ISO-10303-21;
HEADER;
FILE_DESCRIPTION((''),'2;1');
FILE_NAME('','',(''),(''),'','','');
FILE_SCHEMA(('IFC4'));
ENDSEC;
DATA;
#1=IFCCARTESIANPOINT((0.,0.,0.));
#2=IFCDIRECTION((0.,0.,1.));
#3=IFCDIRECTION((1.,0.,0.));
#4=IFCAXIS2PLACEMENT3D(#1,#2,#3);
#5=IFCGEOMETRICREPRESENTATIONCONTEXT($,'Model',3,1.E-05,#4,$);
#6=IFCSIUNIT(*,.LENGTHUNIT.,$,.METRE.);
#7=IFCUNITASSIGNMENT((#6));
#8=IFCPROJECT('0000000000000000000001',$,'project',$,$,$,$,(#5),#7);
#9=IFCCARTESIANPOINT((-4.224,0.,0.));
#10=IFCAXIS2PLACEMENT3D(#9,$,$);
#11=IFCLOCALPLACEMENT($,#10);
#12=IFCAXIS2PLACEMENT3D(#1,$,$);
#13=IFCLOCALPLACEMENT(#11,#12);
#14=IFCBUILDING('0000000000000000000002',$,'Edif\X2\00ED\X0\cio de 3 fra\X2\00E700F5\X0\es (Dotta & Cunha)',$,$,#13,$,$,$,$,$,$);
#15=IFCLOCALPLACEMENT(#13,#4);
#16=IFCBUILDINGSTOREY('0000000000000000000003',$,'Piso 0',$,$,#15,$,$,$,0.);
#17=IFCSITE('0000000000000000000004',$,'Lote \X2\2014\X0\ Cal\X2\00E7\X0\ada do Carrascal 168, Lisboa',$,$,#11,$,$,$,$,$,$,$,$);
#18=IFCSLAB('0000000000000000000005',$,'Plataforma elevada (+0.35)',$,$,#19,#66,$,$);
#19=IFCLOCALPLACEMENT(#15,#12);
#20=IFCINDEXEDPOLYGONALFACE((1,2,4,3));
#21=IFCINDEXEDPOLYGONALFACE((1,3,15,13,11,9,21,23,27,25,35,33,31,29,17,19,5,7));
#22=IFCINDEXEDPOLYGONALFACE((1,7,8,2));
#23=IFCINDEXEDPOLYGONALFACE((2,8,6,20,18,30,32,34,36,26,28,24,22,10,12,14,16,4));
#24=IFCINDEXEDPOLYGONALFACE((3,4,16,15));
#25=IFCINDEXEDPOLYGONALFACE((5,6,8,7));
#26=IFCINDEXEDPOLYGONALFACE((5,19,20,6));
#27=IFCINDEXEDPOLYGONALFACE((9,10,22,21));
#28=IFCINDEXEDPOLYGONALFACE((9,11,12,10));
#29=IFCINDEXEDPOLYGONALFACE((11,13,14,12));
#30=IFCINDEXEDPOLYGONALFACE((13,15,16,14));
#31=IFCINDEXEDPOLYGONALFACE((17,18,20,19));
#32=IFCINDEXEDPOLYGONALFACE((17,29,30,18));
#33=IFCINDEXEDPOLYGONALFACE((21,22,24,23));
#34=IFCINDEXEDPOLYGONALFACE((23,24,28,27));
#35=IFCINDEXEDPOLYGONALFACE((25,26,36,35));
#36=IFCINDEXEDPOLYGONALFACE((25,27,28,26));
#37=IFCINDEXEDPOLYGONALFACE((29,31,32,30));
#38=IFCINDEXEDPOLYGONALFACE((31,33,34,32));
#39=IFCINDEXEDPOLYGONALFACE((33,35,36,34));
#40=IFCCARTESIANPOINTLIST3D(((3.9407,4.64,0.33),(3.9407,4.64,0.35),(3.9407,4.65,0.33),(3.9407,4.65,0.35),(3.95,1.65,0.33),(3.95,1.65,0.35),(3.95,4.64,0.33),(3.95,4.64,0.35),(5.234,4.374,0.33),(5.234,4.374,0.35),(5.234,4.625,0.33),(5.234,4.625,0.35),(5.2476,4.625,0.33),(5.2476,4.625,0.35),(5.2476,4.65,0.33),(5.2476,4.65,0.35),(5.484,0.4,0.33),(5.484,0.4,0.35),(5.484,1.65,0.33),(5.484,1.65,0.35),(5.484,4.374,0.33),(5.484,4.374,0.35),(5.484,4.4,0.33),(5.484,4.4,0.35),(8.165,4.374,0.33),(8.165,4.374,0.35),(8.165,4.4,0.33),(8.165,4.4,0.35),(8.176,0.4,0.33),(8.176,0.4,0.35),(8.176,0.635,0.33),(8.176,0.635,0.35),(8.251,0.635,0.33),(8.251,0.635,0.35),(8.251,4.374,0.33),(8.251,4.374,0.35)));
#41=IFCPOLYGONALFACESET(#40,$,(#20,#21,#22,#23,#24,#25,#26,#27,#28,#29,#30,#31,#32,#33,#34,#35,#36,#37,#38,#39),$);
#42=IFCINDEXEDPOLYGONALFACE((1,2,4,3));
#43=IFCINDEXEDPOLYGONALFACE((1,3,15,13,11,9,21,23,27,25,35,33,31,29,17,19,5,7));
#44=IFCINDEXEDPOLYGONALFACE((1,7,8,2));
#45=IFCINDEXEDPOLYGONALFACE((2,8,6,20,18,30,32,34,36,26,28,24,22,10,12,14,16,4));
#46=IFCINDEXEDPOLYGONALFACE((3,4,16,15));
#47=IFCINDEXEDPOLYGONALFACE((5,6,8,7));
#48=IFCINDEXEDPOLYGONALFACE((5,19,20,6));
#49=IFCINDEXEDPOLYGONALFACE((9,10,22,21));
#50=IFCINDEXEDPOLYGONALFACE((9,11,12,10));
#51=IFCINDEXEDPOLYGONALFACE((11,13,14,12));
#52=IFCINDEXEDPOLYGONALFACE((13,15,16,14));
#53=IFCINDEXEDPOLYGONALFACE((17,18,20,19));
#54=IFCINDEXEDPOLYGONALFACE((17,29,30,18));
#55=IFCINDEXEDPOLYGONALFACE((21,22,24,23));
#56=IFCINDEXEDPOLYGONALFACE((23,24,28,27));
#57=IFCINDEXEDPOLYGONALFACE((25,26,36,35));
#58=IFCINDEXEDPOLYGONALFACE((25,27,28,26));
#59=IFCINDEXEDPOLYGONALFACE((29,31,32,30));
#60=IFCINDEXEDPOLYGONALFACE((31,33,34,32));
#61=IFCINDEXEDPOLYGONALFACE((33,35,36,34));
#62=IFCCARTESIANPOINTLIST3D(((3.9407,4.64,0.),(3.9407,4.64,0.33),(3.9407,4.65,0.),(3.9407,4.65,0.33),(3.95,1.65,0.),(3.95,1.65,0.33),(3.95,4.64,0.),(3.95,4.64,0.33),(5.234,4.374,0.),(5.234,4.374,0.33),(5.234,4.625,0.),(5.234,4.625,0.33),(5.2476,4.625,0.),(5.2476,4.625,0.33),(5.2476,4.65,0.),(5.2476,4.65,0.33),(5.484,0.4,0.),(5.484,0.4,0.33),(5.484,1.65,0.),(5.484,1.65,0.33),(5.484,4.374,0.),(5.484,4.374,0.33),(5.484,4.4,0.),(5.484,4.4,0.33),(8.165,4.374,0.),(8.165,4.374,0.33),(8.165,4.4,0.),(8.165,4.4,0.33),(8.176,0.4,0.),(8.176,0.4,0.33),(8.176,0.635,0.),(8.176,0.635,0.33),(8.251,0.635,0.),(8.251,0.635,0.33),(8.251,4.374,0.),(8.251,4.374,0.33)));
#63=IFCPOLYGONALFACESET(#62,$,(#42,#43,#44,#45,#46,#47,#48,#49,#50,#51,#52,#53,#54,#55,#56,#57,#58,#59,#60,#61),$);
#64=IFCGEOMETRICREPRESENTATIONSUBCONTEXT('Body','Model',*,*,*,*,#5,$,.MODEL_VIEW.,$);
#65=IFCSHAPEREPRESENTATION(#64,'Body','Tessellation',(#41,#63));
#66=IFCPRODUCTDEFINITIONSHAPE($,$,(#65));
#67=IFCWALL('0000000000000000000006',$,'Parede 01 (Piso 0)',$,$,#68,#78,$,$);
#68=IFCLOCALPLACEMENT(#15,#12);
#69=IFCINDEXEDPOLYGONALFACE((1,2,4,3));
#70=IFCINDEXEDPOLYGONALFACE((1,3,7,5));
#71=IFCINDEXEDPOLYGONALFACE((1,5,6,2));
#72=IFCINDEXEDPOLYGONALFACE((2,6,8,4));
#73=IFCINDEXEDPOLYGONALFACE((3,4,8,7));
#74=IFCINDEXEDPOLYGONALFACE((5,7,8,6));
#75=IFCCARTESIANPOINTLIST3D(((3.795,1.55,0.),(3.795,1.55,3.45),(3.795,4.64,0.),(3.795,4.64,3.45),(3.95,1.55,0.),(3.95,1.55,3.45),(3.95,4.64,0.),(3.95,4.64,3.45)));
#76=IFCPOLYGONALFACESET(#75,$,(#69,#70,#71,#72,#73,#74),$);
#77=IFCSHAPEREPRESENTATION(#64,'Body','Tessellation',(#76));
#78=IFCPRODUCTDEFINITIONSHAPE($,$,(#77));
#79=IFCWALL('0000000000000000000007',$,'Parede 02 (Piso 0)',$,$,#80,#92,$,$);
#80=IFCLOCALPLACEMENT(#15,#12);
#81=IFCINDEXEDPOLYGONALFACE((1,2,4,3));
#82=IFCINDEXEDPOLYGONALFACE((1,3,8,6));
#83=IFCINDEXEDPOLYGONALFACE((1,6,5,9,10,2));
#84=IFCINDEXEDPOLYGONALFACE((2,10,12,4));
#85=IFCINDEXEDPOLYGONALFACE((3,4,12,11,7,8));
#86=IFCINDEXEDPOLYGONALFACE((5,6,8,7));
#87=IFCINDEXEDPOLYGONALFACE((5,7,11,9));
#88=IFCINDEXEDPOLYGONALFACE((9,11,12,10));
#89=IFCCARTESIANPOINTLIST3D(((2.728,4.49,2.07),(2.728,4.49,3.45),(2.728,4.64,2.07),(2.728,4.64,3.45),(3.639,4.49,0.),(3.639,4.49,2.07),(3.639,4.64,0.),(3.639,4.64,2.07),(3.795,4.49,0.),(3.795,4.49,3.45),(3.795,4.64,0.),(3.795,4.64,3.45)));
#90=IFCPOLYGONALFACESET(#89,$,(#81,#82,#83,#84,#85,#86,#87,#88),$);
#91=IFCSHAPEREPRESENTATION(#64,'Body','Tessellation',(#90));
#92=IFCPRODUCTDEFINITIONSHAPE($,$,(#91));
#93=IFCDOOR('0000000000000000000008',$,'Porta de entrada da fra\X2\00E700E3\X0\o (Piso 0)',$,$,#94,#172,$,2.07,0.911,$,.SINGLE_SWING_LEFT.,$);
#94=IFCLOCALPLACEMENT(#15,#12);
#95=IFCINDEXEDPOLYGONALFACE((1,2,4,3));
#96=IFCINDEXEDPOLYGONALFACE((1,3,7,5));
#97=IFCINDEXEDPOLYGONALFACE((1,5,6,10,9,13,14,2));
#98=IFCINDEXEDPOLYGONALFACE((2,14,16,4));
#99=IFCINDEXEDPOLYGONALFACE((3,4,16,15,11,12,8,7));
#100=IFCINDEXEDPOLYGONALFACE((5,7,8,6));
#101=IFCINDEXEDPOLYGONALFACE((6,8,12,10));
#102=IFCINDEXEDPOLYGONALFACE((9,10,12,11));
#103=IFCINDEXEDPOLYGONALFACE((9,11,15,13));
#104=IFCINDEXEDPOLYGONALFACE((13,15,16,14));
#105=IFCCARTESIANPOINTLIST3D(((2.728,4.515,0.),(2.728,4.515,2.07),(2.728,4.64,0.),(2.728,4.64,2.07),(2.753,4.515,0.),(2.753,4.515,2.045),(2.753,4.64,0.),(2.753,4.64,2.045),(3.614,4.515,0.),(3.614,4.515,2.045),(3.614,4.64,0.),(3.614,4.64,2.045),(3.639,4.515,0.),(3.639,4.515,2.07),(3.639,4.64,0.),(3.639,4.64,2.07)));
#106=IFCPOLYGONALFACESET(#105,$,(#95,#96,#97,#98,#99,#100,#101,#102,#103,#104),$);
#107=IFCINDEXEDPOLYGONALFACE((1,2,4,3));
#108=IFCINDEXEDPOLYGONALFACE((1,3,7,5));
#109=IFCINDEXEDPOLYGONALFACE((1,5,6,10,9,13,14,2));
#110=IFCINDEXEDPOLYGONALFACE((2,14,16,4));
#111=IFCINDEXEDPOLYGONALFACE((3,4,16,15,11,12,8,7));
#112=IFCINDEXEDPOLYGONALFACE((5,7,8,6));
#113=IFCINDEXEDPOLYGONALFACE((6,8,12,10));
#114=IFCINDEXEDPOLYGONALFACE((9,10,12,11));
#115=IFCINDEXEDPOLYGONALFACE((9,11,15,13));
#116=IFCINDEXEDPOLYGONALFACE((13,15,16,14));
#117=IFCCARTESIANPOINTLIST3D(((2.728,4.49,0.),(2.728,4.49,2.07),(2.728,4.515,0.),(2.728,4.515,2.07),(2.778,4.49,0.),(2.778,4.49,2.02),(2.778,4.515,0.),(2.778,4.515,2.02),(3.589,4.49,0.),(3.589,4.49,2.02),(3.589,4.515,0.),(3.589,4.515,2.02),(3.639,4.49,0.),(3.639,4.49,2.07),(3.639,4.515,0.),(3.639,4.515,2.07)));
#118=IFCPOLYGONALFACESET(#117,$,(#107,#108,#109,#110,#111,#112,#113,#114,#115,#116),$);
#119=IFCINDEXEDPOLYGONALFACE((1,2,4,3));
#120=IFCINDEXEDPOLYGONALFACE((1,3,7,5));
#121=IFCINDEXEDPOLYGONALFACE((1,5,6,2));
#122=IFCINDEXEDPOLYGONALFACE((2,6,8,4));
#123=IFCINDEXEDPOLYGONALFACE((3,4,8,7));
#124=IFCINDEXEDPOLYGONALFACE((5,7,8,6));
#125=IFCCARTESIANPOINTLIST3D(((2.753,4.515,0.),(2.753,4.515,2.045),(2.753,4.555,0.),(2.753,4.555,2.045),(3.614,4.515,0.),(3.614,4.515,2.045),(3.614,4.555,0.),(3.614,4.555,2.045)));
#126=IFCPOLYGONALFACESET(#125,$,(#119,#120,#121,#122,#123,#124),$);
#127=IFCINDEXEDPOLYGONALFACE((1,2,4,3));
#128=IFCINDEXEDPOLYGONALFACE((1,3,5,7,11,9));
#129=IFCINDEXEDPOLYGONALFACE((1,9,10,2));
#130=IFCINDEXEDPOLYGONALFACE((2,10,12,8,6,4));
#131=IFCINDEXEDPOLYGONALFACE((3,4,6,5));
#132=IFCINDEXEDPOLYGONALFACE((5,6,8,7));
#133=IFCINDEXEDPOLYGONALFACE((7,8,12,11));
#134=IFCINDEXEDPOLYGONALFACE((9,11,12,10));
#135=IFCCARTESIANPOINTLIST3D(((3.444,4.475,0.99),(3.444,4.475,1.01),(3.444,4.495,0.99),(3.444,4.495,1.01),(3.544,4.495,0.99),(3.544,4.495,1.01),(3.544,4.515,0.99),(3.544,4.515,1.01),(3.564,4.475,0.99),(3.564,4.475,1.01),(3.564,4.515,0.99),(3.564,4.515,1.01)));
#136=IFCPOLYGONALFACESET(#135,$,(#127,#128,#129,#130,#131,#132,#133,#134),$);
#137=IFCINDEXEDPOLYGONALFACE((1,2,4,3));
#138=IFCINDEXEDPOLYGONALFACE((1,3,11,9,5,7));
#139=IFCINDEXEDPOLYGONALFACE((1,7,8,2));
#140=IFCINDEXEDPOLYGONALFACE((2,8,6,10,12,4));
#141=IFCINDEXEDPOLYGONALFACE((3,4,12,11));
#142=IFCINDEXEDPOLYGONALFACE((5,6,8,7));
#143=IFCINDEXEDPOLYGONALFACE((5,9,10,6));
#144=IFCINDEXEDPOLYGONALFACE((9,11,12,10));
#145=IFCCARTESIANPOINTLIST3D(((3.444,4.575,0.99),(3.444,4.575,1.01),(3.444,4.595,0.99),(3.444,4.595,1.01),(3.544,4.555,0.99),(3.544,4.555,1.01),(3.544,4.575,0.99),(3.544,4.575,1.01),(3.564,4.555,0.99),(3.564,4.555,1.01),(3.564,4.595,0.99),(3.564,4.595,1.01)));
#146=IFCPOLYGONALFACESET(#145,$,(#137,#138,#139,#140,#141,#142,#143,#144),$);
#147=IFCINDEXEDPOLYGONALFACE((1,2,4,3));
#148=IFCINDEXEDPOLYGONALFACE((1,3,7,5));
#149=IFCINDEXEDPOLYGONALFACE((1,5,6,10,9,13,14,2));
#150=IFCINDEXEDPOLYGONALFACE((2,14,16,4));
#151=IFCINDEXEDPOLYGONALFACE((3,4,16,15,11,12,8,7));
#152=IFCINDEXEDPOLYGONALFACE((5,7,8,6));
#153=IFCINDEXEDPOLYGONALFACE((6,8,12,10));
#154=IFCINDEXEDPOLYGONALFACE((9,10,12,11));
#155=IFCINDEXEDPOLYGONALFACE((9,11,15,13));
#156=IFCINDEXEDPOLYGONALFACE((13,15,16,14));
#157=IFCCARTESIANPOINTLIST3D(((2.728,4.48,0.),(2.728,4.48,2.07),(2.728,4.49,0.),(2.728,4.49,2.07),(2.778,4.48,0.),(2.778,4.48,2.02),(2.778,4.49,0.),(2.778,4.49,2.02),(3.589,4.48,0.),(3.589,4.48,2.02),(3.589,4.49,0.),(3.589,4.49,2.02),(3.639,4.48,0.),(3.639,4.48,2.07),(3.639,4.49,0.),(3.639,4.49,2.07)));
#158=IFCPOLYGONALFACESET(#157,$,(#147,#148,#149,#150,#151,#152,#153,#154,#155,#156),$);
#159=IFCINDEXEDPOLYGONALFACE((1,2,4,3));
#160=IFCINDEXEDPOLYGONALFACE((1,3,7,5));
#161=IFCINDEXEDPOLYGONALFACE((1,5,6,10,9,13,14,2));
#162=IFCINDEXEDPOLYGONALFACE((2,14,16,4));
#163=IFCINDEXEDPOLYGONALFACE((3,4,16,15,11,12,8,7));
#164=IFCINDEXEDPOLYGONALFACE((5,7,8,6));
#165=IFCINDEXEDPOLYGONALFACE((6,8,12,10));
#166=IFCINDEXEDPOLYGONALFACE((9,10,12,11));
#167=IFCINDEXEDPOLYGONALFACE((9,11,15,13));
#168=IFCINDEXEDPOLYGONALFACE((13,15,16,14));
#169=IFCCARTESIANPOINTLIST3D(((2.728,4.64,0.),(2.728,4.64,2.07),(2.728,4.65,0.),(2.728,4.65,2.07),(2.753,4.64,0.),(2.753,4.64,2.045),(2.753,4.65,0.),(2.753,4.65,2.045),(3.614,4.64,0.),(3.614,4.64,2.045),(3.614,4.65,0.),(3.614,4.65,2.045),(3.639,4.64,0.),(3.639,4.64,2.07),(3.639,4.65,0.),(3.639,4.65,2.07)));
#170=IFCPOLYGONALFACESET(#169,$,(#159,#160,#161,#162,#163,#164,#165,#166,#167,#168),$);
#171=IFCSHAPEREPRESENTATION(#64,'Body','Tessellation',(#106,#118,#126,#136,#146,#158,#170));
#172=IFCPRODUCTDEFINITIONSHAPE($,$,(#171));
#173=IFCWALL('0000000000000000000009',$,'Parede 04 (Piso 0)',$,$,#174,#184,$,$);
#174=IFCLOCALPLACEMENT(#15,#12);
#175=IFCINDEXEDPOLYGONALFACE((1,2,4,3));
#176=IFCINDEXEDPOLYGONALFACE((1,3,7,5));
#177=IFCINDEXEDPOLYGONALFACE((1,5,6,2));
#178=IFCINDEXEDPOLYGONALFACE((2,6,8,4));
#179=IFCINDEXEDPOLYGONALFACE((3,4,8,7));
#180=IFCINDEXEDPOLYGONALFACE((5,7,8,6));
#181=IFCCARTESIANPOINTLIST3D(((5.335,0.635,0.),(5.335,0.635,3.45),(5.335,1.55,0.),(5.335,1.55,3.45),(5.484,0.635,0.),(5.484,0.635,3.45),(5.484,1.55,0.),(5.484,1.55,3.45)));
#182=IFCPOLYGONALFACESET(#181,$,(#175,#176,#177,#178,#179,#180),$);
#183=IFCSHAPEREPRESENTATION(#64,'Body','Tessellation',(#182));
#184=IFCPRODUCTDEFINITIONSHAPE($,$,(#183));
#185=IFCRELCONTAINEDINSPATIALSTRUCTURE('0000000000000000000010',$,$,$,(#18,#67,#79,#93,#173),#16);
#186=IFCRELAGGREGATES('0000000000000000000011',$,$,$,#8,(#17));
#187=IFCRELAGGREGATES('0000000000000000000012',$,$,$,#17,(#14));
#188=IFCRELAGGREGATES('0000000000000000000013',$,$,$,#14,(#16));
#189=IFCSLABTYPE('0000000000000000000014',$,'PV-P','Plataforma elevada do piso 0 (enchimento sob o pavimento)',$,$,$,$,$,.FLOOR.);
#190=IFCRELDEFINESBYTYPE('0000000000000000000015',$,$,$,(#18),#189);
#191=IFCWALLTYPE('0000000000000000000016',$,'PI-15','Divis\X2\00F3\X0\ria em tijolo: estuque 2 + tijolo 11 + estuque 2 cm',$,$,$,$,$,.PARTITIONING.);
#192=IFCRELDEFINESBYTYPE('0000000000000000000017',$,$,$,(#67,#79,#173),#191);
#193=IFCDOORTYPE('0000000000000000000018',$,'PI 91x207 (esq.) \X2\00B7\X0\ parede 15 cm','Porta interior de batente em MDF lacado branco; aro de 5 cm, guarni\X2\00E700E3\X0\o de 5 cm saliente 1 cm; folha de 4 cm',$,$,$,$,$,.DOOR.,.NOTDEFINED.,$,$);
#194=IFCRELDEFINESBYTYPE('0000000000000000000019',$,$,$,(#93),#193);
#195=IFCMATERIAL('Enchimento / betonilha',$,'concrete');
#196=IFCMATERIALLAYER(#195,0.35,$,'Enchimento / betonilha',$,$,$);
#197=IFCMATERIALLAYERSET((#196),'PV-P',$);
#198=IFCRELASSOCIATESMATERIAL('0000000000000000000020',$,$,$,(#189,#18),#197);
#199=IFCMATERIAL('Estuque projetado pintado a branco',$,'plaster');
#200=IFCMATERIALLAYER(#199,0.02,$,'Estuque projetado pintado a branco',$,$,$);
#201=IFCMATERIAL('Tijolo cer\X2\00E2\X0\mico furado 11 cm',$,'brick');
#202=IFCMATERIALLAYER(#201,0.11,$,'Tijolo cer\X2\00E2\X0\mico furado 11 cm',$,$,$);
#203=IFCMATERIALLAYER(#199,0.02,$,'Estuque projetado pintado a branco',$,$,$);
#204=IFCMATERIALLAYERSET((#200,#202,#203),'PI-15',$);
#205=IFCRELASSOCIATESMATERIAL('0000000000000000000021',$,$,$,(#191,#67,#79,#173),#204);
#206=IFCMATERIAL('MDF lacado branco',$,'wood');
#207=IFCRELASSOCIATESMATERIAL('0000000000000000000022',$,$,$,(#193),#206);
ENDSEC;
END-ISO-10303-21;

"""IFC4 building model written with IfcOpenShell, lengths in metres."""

from ifc_helpers import new_model, si_unit, frame, origin, origin_with_axes, place, context, subcontext, project, spatial, line, indexed_curve, outline, extrude, source, transform, mapped, material, layer, layer_set, layer_usage, type_object, type_shapes, element, fill, save


model = new_model("IFC4")

# Units and contexts
model_context = context("Model", 3, precision=1e-05, world=origin_with_axes())
body_context = subcontext(model_context, "Body", "Model", "MODEL_VIEW")
ifc_project = project(units=[si_unit("LENGTHUNIT", "METRE")], contexts=[model_context])

# Site, building, storey
site_placement = place(None, frame((-4.224, 0.0, 0.0)))
site = spatial("IfcSite", under=ifc_project, at=site_placement, Name="Lote — Calçada do Carrascal 168, Lisboa")
building_placement = place(site_placement, origin())
building = spatial("IfcBuilding", under=site, at=building_placement, Name="Edifício de 3 frações (Dotta & Cunha)")
storey_placement = place(building_placement, origin_with_axes())
storey = spatial("IfcBuildingStorey", under=building, at=storey_placement, Name="Piso 0", Elevation=0.0)

# Slab
ifc_material_1 = material(Name="Enchimento / betonilha", Category="concrete")
ifc_layer_1 = layer(ifc_material_1, 0.35, Name="Enchimento / betonilha")
ifc_layer_set_1 = layer_set([ifc_layer_1], Name="PV-P")
slab_type = type_object("IfcSlabType", Name="PV-P", Description="Plataforma elevada do piso 0 (enchimento sob o pavimento)", PredefinedType="FLOOR", material=ifc_layer_set_1)
ifc_layer_usage_1 = layer_usage(ifc_layer_set_1, "AXIS3", "POSITIVE", 0.0)
slab_1_placement = place(storey_placement, origin_with_axes())
element("IfcSlab", 1, at=slab_1_placement, inside=storey, type_object=slab_type, material=ifc_layer_usage_1, Name="Plataforma elevada (+0.35)", context=body_context, shape_type="SweptSolid", body=[
    extrude(outline(indexed_curve([(5.484, 0.4), (5.484, 1.65), (3.95, 1.65), (3.95, 4.64), (3.9407, 4.64), (3.9407, 4.65), (5.2476, 4.65), (5.2476, 4.625), (5.234, 4.625), (5.234, 4.374), (5.484, 4.374), (5.484, 4.4), (8.165, 4.4), (8.165, 4.374), (8.251, 4.374), (8.251, 0.635), (8.176, 0.635), (8.176, 0.4)], segments=[line(1, 2, 3, 4, 5, 6, 7, 8, 9, 10, 11, 12, 13, 14, 15, 16, 17, 18, 1)])), frame((0.0, 0.0, 0.33), z_axis=(0.0, 0.0, 1.0), x_axis=(1.0, 0.0, 0.0)), (0.0, 0.0, 1.0), 0.02),
    extrude(outline(indexed_curve([(5.484, 0.4), (5.484, 1.65), (3.95, 1.65), (3.95, 4.64), (3.9407, 4.64), (3.9407, 4.65), (5.2476, 4.65), (5.2476, 4.625), (5.234, 4.625), (5.234, 4.374), (5.484, 4.374), (5.484, 4.4), (8.165, 4.4), (8.165, 4.374), (8.251, 4.374), (8.251, 0.635), (8.176, 0.635), (8.176, 0.4)], segments=[line(1, 2, 3, 4, 5, 6, 7, 8, 9, 10, 11, 12, 13, 14, 15, 16, 17, 18, 1)])), origin_with_axes(), (0.0, 0.0, 1.0), 0.33),
])

# Wall
ifc_material_2 = material(Name="Estuque projetado pintado a branco", Category="plaster")
ifc_layer_2 = layer(ifc_material_2, 0.02, Name="Estuque projetado pintado a branco")
ifc_material_3 = material(Name="Tijolo cerâmico furado 11 cm", Category="brick")
ifc_layer_3 = layer(ifc_material_3, 0.11, Name="Tijolo cerâmico furado 11 cm")
ifc_layer_4 = layer(ifc_material_2, 0.02, Name="Estuque projetado pintado a branco")
ifc_layer_set_2 = layer_set([ifc_layer_2, ifc_layer_3, ifc_layer_4], Name="PI-15")
ifc_layer_usage_2 = layer_usage(ifc_layer_set_2, "AXIS2", "POSITIVE", 0.0)
wall_type_1 = type_object("IfcWallType", Name="PI-15", Description="Divisória em tijolo: estuque 2 + tijolo 11 + estuque 2 cm", PredefinedType="PARTITIONING", material=ifc_layer_set_2)
wall_1_placement = place(storey_placement, origin_with_axes())
element("IfcWall", 2, at=wall_1_placement, inside=storey, type_object=wall_type_1, material=ifc_layer_usage_2, Name="Parede 01 (Piso 0)", context=body_context, shape_type="SweptSolid", body=[
    extrude(outline(indexed_curve([(3.95, 1.55), (3.95, 4.64), (3.795, 4.64), (3.795, 1.55)], segments=[line(1, 2, 3, 4, 1)])), origin_with_axes(), (0.0, 0.0, 1.0), 3.45),
])

# Wall, opening, door
ifc_layer_usage_3 = layer_usage(ifc_layer_set_2, "AXIS2", "POSITIVE", 0.0)
wall_2_placement = place(storey_placement, origin_with_axes())
wall_2 = element("IfcWall", 3, at=wall_2_placement, inside=storey, type_object=wall_type_1, material=ifc_layer_usage_3, Name="Parede 02 (Piso 0)", context=body_context, shape_type="SweptSolid", body=[
    extrude(outline(indexed_curve([(3.795, 4.49), (3.795, 4.64), (2.728, 4.64), (2.728, 4.49)], segments=[line(1, 2, 3, 4, 1)])), origin_with_axes(), (0.0, 0.0, 1.0), 3.45),
])
opening_placement = place(wall_2_placement, origin_with_axes())
opening = element("IfcOpeningElement", 4, at=opening_placement, cuts=wall_2, context=body_context, shape_type="SweptSolid", body=[
    extrude(outline(indexed_curve([(3.639, 4.488), (3.639, 4.642), (2.728, 4.642), (2.728, 4.488)], segments=[line(1, 2, 3, 4, 1)])), origin_with_axes(), (0.0, 0.0, 1.0), 2.07),
])
ifc_material_4 = material(Name="MDF lacado branco", Category="wood")
door_type = type_object("IfcDoorType", Name="PI 91x207 (esq.) · parede 15 cm", Description="Porta interior de batente em MDF lacado branco; aro de 5 cm, guarnição de 5 cm saliente 1 cm; folha de 4 cm", OperationType="NOTDEFINED", PredefinedType="DOOR", material=ifc_material_4)
shared_shape = source(origin_with_axes(), body_context, "Body", "SweptSolid", [
    extrude(outline(indexed_curve([(0.0, 0.0), (0.0, 2.07), (0.911, 2.07), (0.911, 0.0), (0.886, 0.0), (0.886, 2.045), (0.025, 2.045), (0.025, 0.0)], segments=[line(1, 2, 3, 4, 5, 6, 7, 8, 1)])), frame((0.0, 0.025, 0.0), z_axis=(0.0, -1.0, 0.0), x_axis=(1.0, 0.0, 0.0)), (0.0, 0.0, -1.0), 0.125),
    extrude(outline(indexed_curve([(0.0, 0.0), (0.0, 2.07), (0.911, 2.07), (0.911, 0.0), (0.861, 0.0), (0.861, 2.02), (0.05, 2.02), (0.05, 0.0)], segments=[line(1, 2, 3, 4, 5, 6, 7, 8, 1)])), frame((0.0, 0.0, 0.0), z_axis=(0.0, -1.0, 0.0), x_axis=(1.0, 0.0, 0.0)), (0.0, 0.0, -1.0), 0.025),
    extrude(outline(indexed_curve([(0.0, 0.0), (0.861, 0.0), (0.861, 0.04), (0.0, 0.04)], segments=[line(1, 2, 3, 4, 1)])), frame((0.025, 0.025, 0.0), z_axis=(0.0, 0.0, 1.0), x_axis=(1.0, 0.0, 0.0)), (0.0, 0.0, 1.0), 2.045),
    extrude(outline(indexed_curve([(0.0, 0.0), (0.0, -0.04), (-0.12, -0.04), (-0.12, -0.02), (-0.02, -0.02), (-0.02, 0.0)], segments=[line(1, 2, 3, 4, 5, 6, 1)])), frame((0.836, 0.025, 0.99), z_axis=(0.0, 0.0, 1.0), x_axis=(1.0, 0.0, 0.0)), (0.0, 0.0, 1.0), 0.02),
    extrude(outline(indexed_curve([(0.0, 0.0), (0.0, 0.04), (-0.12, 0.04), (-0.12, 0.02), (-0.02, 0.02), (-0.02, 0.0)], segments=[line(1, 2, 3, 4, 5, 6, 1)])), frame((0.836, 0.065, 0.99), z_axis=(0.0, 0.0, 1.0), x_axis=(1.0, 0.0, 0.0)), (0.0, 0.0, 1.0), 0.02),
    extrude(outline(indexed_curve([(0.0, 0.0), (0.0, 2.07), (0.911, 2.07), (0.911, 0.0), (0.861, 0.0), (0.861, 2.02), (0.05, 2.02), (0.05, 0.0)], segments=[line(1, 2, 3, 4, 5, 6, 7, 8, 1)])), frame((0.0, -0.01, 0.0), z_axis=(0.0, -1.0, 0.0), x_axis=(1.0, 0.0, 0.0)), (0.0, 0.0, -1.0), 0.01),
    extrude(outline(indexed_curve([(0.0, 0.0), (0.0, 2.07), (0.911, 2.07), (0.911, 0.0), (0.886, 0.0), (0.886, 2.045), (0.025, 2.045), (0.025, 0.0)], segments=[line(1, 2, 3, 4, 5, 6, 7, 8, 1)])), frame((0.0, 0.15, 0.0), z_axis=(0.0, -1.0, 0.0), x_axis=(1.0, 0.0, 0.0)), (0.0, 0.0, -1.0), 0.01),
])
type_shapes(door_type, [shared_shape])
door_placement = place(storey_placement, frame((2.728, 4.49, 0.0), z_axis=(0.0, 0.0, 1.0), x_axis=(1.0, 0.0, 0.0)))
door = element("IfcDoor", 5, at=door_placement, inside=storey, type_object=door_type, Name="Porta de entrada da fração (Piso 0)", OperationType="SINGLE_SWING_LEFT", OverallHeight=2.07, OverallWidth=0.911, context=body_context, shape_type="MappedRepresentation", body=[
    mapped(shared_shape, transform((0.0, 0.0, 0.0), x_axis=(1.0, 0.0, 0.0), y_axis=(0.0, 1.0, 0.0), z_axis=(0.0, 0.0, 1.0), scale=1.0)),
])
fill(opening, door)

# Wall
ifc_layer_usage_4 = layer_usage(ifc_layer_set_2, "AXIS2", "POSITIVE", 0.0)
wall_3_placement = place(storey_placement, origin_with_axes())
element("IfcWall", 6, at=wall_3_placement, inside=storey, type_object=wall_type_1, material=ifc_layer_usage_4, Name="Parede 04 (Piso 0)", context=body_context, shape_type="SweptSolid", body=[
    extrude(outline(indexed_curve([(5.484, 0.635), (5.484, 1.55), (5.335, 1.55), (5.335, 0.635)], segments=[line(1, 2, 3, 4, 1)])), origin_with_axes(), (0.0, 0.0, 1.0), 3.45),
])

save(model, "model.ifc")
